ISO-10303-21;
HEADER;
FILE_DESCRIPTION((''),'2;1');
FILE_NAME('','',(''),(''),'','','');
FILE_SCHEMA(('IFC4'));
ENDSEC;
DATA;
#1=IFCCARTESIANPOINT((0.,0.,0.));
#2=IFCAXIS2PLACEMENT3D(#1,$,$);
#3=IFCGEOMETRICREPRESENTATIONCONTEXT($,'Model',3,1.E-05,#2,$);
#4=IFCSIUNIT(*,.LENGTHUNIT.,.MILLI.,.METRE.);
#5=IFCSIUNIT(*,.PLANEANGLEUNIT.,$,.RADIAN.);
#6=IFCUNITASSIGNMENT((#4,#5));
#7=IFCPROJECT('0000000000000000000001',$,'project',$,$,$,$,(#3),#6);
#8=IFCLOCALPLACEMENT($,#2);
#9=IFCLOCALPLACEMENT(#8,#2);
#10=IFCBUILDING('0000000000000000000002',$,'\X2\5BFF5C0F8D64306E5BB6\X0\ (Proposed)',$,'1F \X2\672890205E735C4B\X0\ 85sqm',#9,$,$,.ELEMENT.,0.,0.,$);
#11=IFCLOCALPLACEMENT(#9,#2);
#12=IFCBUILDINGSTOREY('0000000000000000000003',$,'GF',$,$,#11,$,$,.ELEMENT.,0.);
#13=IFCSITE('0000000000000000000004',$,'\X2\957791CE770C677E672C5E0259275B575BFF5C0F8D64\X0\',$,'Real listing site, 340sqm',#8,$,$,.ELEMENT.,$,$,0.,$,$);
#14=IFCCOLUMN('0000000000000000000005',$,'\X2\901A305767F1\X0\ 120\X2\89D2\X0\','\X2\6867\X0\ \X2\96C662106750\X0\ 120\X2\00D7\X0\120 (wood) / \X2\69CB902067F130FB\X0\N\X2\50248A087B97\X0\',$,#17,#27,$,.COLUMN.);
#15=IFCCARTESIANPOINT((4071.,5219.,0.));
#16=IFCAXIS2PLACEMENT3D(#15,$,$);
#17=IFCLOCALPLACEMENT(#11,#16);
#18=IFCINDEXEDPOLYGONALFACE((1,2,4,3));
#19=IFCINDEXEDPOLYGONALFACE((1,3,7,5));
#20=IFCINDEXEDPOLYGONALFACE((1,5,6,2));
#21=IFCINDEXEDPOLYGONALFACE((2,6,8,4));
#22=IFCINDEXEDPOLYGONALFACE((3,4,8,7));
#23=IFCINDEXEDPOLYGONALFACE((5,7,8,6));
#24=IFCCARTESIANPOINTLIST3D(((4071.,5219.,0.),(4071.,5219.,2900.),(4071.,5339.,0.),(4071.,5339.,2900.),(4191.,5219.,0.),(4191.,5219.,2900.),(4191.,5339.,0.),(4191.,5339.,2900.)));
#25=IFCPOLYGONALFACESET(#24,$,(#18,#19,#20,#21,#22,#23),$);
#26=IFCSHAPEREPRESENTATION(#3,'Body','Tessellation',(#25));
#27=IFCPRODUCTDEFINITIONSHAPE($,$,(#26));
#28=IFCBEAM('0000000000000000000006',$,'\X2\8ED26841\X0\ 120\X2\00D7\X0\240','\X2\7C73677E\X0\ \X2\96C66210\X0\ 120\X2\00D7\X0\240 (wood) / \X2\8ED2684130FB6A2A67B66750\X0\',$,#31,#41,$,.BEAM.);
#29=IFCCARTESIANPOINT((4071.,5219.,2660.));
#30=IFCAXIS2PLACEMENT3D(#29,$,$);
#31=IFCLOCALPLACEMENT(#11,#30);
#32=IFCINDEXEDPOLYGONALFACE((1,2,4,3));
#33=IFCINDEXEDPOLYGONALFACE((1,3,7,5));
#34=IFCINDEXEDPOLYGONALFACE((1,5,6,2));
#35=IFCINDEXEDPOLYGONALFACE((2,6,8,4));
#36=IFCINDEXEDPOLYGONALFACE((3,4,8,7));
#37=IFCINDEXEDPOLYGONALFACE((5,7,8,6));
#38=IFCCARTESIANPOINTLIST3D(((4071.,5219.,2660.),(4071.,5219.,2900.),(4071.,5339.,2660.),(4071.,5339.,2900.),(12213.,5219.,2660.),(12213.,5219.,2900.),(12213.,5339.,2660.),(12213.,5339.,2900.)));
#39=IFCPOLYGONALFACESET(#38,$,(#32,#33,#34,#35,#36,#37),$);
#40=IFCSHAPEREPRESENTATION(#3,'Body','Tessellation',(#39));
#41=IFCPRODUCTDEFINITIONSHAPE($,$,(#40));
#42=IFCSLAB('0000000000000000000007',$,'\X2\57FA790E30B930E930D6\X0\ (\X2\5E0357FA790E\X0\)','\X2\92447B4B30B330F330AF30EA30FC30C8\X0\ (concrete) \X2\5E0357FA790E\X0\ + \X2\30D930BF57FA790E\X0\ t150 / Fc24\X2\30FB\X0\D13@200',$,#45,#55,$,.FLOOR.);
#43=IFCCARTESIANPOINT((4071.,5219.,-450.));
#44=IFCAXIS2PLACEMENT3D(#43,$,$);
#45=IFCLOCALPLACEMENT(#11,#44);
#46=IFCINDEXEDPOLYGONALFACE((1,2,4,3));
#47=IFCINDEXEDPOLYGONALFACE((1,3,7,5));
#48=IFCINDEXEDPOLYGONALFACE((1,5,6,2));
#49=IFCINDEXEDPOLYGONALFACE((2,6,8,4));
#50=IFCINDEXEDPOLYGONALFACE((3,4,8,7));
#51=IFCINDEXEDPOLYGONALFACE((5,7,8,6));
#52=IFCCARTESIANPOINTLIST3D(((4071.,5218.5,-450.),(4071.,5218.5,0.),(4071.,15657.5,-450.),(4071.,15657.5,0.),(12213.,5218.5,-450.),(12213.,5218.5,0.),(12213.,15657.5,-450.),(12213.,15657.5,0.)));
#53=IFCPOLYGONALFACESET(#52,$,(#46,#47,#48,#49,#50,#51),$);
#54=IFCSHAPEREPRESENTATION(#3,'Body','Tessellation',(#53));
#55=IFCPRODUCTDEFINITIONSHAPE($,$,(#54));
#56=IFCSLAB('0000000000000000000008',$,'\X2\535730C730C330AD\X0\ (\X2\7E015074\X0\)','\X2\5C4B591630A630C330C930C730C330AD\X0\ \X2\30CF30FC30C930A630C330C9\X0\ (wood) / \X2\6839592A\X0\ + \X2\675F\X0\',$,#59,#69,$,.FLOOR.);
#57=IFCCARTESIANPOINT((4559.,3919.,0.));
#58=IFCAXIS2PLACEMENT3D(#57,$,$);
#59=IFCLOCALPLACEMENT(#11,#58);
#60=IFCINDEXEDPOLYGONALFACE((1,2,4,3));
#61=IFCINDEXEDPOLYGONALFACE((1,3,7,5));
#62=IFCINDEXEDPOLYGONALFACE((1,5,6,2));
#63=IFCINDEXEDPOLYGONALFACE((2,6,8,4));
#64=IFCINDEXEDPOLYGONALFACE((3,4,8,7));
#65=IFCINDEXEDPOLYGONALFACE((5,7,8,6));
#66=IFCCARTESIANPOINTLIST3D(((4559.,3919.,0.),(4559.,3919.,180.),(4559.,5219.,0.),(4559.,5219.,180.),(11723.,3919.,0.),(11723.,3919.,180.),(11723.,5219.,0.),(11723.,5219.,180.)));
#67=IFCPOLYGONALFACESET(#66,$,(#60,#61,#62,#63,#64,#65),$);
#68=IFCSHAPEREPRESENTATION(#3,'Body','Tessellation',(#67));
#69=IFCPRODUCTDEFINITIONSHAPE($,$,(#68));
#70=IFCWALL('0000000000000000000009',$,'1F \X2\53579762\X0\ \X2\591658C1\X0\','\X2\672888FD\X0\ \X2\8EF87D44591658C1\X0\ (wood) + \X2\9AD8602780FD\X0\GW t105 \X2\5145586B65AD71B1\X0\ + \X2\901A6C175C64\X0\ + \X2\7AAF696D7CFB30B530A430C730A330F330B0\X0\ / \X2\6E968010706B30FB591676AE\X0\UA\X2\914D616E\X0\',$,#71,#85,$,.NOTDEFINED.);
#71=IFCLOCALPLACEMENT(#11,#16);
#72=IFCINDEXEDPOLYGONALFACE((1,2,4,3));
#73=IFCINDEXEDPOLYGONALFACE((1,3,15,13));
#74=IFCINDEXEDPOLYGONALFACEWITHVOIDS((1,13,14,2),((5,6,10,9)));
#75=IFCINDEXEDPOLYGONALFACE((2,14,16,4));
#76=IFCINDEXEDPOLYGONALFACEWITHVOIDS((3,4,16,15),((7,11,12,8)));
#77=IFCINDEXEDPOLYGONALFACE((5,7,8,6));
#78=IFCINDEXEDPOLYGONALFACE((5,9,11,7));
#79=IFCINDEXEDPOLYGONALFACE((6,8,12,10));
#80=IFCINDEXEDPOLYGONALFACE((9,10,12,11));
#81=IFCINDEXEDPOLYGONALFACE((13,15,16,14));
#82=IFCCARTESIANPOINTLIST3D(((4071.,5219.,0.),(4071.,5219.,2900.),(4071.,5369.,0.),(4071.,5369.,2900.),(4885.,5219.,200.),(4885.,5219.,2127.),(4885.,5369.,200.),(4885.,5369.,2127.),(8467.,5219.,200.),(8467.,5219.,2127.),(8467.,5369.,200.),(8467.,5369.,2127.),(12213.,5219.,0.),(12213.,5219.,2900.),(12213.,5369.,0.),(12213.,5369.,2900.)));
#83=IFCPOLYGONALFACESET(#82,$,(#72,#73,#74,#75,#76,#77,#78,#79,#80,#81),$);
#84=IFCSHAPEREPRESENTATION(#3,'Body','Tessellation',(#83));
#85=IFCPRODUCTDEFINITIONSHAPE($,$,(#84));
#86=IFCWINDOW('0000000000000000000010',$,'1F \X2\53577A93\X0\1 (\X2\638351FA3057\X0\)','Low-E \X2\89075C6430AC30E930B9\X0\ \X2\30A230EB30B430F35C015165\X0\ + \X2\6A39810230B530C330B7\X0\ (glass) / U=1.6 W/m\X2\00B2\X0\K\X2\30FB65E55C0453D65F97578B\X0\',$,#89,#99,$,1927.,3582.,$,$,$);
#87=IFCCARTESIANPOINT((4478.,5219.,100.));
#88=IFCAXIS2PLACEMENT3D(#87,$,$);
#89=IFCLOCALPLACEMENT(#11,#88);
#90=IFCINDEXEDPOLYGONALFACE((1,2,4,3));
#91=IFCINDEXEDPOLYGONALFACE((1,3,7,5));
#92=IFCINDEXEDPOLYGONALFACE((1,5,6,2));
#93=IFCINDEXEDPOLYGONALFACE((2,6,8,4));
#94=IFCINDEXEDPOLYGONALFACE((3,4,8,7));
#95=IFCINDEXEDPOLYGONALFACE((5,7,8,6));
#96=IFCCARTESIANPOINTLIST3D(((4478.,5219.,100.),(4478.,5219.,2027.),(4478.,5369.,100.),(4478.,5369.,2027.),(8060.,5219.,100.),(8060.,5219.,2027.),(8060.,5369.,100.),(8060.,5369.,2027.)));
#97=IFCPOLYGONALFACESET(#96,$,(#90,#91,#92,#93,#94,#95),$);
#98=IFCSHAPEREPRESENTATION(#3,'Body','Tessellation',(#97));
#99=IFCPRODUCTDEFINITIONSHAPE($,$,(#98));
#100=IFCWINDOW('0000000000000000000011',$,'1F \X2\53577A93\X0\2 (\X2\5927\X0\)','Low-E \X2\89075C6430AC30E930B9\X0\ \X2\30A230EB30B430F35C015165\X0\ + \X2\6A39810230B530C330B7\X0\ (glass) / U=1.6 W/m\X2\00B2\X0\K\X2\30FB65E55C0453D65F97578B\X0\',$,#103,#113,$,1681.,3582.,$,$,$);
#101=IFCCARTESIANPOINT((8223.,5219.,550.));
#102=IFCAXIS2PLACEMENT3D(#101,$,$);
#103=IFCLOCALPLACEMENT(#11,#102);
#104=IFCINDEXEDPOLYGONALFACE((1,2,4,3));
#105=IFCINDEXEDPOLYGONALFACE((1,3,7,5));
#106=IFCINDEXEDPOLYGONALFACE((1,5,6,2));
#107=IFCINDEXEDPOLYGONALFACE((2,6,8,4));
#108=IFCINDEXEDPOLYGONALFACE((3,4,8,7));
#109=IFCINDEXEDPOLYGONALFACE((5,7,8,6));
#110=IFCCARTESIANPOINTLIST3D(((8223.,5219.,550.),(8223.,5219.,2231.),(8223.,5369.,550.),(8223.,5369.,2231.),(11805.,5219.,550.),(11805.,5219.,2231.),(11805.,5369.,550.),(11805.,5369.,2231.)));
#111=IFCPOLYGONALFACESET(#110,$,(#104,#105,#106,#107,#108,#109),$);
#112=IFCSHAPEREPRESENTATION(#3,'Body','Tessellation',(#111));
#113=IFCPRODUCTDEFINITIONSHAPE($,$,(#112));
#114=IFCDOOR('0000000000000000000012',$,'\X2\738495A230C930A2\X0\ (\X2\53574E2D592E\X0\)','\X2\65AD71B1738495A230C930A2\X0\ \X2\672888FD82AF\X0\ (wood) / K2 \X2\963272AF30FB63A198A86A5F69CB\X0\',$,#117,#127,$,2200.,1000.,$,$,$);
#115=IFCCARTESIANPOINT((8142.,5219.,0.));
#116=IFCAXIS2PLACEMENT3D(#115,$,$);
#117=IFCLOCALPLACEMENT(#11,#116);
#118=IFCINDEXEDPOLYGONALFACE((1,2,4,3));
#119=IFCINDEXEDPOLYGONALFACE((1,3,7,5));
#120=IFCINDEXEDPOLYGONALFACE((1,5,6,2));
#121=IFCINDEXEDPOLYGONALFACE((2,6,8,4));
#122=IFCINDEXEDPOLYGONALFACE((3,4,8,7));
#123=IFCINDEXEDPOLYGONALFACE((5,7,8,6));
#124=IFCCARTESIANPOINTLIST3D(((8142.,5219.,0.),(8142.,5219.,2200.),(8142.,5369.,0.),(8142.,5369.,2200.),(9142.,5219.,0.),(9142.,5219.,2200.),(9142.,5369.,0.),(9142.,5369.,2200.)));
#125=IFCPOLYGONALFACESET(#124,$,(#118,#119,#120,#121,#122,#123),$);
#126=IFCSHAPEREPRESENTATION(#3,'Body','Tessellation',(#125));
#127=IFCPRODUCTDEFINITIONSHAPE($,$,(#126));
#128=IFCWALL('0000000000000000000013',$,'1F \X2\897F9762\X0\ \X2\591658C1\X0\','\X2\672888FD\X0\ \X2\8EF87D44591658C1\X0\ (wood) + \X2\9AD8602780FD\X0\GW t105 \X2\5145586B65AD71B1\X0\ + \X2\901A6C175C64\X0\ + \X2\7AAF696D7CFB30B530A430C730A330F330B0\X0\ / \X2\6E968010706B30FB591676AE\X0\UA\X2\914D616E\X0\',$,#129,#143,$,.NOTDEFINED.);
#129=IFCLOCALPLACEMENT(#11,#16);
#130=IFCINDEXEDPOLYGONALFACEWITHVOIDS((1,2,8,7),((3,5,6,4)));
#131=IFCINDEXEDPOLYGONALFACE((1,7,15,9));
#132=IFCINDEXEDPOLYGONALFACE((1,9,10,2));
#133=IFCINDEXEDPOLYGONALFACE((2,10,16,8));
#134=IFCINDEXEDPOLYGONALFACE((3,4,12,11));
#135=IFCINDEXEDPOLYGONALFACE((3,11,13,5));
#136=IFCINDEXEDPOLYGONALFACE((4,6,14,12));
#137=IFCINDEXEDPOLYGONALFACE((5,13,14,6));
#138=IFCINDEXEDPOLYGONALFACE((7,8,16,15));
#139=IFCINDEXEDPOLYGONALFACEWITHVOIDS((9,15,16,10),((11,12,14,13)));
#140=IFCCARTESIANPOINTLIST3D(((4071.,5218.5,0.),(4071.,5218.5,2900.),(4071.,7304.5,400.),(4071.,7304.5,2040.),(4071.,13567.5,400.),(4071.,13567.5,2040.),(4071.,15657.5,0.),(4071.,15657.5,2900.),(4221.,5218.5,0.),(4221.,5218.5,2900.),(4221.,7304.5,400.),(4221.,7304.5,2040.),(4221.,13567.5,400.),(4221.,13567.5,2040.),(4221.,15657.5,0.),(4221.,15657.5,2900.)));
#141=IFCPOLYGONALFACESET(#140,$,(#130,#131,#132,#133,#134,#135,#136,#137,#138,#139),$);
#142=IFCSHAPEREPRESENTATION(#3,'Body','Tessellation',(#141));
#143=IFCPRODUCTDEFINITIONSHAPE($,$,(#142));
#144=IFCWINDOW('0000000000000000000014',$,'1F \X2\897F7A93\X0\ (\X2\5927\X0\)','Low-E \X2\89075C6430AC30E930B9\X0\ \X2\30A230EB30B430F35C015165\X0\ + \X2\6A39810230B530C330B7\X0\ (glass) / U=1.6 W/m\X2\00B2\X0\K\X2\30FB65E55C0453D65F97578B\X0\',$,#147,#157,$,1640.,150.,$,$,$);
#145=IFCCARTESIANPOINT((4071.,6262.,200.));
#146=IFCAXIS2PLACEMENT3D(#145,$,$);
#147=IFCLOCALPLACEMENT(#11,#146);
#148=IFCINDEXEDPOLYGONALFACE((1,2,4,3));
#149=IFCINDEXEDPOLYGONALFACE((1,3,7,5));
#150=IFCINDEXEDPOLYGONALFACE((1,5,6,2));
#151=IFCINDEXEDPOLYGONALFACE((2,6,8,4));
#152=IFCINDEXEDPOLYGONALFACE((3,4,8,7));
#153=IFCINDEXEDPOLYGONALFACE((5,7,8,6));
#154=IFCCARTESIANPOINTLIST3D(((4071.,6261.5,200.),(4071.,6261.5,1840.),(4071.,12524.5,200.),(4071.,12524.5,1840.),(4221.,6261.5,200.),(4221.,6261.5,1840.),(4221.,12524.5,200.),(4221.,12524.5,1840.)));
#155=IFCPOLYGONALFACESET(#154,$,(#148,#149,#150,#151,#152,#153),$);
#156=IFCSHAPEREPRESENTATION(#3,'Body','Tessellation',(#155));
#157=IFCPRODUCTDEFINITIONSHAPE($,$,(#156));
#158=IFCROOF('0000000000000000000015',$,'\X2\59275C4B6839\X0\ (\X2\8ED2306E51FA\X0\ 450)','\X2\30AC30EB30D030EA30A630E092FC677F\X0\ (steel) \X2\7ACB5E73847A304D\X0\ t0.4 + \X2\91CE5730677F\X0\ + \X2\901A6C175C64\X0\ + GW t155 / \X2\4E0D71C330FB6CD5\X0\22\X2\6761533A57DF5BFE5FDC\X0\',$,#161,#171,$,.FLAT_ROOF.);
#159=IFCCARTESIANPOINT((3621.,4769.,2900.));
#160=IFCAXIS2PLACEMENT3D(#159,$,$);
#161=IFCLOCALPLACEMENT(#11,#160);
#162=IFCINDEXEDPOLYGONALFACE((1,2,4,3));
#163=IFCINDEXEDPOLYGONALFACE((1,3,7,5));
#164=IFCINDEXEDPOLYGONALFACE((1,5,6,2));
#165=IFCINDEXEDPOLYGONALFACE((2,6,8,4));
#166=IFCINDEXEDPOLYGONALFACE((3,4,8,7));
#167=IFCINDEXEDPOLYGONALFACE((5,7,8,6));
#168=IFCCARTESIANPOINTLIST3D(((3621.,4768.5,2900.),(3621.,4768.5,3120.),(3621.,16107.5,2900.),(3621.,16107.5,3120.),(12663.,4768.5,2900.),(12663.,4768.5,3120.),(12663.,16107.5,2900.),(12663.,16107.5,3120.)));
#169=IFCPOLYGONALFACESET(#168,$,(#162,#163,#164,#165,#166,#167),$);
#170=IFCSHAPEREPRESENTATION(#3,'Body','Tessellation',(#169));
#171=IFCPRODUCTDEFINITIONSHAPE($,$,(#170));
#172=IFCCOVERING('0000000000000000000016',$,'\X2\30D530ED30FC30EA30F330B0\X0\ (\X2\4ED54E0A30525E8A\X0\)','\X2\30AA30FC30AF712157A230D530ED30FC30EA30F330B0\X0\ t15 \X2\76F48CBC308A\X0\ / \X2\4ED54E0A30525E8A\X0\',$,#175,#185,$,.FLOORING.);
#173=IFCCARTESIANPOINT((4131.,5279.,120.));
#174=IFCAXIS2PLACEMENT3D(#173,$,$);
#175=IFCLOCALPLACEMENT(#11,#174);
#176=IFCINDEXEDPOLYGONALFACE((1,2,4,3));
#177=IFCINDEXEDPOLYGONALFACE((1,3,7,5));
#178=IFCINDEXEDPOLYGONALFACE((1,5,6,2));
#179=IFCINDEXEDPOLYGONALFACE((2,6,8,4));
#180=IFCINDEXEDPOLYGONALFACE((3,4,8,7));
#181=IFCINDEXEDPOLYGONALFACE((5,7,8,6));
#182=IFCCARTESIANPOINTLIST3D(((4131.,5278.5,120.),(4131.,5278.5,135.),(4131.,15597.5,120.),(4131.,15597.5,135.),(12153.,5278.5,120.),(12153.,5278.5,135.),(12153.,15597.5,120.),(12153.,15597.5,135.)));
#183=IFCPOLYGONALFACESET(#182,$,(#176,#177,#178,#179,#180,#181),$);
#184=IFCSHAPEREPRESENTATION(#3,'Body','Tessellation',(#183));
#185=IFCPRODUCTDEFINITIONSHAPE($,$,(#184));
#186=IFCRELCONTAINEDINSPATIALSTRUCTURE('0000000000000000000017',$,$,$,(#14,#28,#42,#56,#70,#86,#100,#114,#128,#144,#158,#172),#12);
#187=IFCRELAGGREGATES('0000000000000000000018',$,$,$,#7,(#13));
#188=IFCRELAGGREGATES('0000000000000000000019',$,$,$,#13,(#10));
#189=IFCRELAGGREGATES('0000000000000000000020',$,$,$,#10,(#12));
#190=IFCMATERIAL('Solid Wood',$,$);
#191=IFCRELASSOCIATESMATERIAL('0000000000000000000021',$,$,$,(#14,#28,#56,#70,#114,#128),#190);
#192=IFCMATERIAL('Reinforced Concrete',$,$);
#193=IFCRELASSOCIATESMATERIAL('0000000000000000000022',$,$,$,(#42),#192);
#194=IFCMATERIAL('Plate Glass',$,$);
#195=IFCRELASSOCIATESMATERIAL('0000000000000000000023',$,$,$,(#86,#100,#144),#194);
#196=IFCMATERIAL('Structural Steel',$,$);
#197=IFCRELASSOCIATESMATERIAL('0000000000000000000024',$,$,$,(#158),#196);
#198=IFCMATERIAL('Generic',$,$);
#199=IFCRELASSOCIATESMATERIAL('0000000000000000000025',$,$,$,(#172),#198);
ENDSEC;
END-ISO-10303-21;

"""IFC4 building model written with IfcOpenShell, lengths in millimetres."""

from ifc_helpers import new_model, si_unit, frame, frame_2d, origin, place, context, project, spatial, rectangle, extrude, material, element, fill, save


model = new_model("IFC4")

# Units and contexts
model_context = context("Model", 3, precision=1e-05, world=origin())
ifc_project = project(units=[si_unit("LENGTHUNIT", "METRE", prefix="MILLI"), si_unit("PLANEANGLEUNIT", "RADIAN")], contexts=[model_context])

# Site, building, storey
site_placement = place(None, origin())
site = spatial("IfcSite", under=ifc_project, at=site_placement, Name="長野県松本市大字寿小赤", ObjectType="Real listing site, 340sqm", CompositionType="ELEMENT", RefElevation=0.0)
building_placement = place(site_placement, origin())
building = spatial("IfcBuilding", under=site, at=building_placement, Name="寿小赤の家 (Proposed)", ObjectType="1F 木造平屋 85sqm", CompositionType="ELEMENT", ElevationOfRefHeight=0.0, ElevationOfTerrain=0.0)
storey_placement = place(building_placement, origin())
storey = spatial("IfcBuildingStorey", under=building, at=storey_placement, Name="GF", CompositionType="ELEMENT", Elevation=0.0)

# Column
ifc_material_1 = material(Name="Solid Wood")
column_1_placement = place(storey_placement, frame((4071.0, 5219.0, 0.0)))
element("IfcColumn", 1, at=column_1_placement, inside=storey, material=ifc_material_1, Name="通し柱 120角", Description="桧 集成材 120×120 (wood) / 構造柱・N値計算", PredefinedType="COLUMN", context=model_context, shape_type="SweptSolid", body=[
    extrude(rectangle(XDim=120.0, YDim=120.0, at=frame_2d((60.0, 60.0))), frame((4071.0, 5219.0, 0.0)), (0.0, 0.0, 1.0), 2900.0),
])

# Beam
beam_1_placement = place(storey_placement, frame((4071.0, 5219.0, 2660.0)))
element("IfcBeam", 2, at=beam_1_placement, inside=storey, material=ifc_material_1, Name="軒桁 120×240", Description="米松 集成 120×240 (wood) / 軒桁・横架材", PredefinedType="BEAM", context=model_context, shape_type="SweptSolid", body=[
    extrude(rectangle(XDim=8142.0, YDim=120.0, at=frame_2d((4071.0, 60.0))), frame((4071.0, 5219.0, 2660.0)), (0.0, 0.0, 1.0), 240.0),
])

# Slabs
ifc_material_2 = material(Name="Reinforced Concrete")
slab_1_placement = place(storey_placement, frame((4071.0, 5219.0, -450.0)))
element("IfcSlab", 3, at=slab_1_placement, inside=storey, material=ifc_material_2, Name="基礎スラブ (布基礎)", Description="鉄筋コンクリート (concrete) 布基礎 + ベタ基礎 t150 / Fc24・D13@200", PredefinedType="FLOOR", context=model_context, shape_type="SweptSolid", body=[
    extrude(rectangle(XDim=8142.0, YDim=10439.0, at=frame_2d((4071.0, 5219.0))), frame((4071.0, 5219.0, -450.0)), (0.0, 0.0, 1.0), 450.0),
])
slab_2_placement = place(storey_placement, frame((4559.0, 3919.0, 0.0)))
element("IfcSlab", 4, at=slab_2_placement, inside=storey, material=ifc_material_1, Name="南デッキ (縁側)", Description="屋外ウッドデッキ ハードウッド (wood) / 根太 + 束", PredefinedType="FLOOR", context=model_context, shape_type="SweptSolid", body=[
    extrude(rectangle(XDim=7164.0, YDim=1300.0, at=frame_2d((3582.0, 650.0))), frame((4559.0, 3919.0, 0.0)), (0.0, 0.0, 1.0), 180.0),
])

# Wall, openings, windows, door
wall_1_placement = place(storey_placement, frame((4071.0, 5219.0, 0.0)))
wall_1 = element("IfcWall", 5, at=wall_1_placement, inside=storey, material=ifc_material_1, Name="1F 南面 外壁", Description="木製 軸組外壁 (wood) + 高性能GW t105 充填断熱 + 通気層 + 窯業系サイディング / 準耐火・外皮UA配慮", PredefinedType="NOTDEFINED", context=model_context, shape_type="SweptSolid", body=[
    extrude(rectangle(XDim=8142.0, YDim=150.0, at=frame_2d((4071.0, 75.0))), frame((4071.0, 5219.0, 0.0)), (0.0, 0.0, 1.0), 2900.0),
])
opening_1_placement = place(storey_placement, frame((4478.0, 5219.0, 100.0)))
opening_1 = element("IfcOpeningElement", 6, at=opening_1_placement, cuts=wall_1, PredefinedType="NOTDEFINED", context=model_context, shape_type="SweptSolid", body=[
    extrude(rectangle(XDim=3582.0, YDim=150.0, at=frame_2d((1791.0, 75.0))), frame((4478.0, 5219.0, 100.0)), (0.0, 0.0, 1.0), 1927.0),
])
opening_2_placement = place(storey_placement, frame((8223.0, 5219.0, 550.0)))
opening_2 = element("IfcOpeningElement", 7, at=opening_2_placement, cuts=wall_1, PredefinedType="NOTDEFINED", context=model_context, shape_type="SweptSolid", body=[
    extrude(rectangle(XDim=3582.0, YDim=150.0, at=frame_2d((1791.0, 75.0))), frame((8223.0, 5219.0, 550.0)), (0.0, 0.0, 1.0), 1681.0),
])
opening_3_placement = place(storey_placement, frame((8142.0, 5219.0, 0.0)))
opening_3 = element("IfcOpeningElement", 8, at=opening_3_placement, cuts=wall_1, PredefinedType="NOTDEFINED", context=model_context, shape_type="SweptSolid", body=[
    extrude(rectangle(XDim=1000.0, YDim=150.0, at=frame_2d((500.0, 75.0))), frame((8142.0, 5219.0, 0.0)), (0.0, 0.0, 1.0), 2200.0),
])
ifc_material_3 = material(Name="Plate Glass")
window_1_placement = place(storey_placement, frame((4478.0, 5219.0, 100.0)))
window_1 = element("IfcWindow", 9, at=window_1_placement, inside=storey, material=ifc_material_3, Name="1F 南窓1 (掃出し)", Description="Low-E 複層ガラス アルゴン封入 + 樹脂サッシ (glass) / U=1.6 W/m²K・日射取得型", OverallHeight=1927.0, OverallWidth=3582.0, context=model_context, shape_type="SweptSolid", body=[
    extrude(rectangle(XDim=3582.0, YDim=150.0, at=frame_2d((1791.0, 75.0))), frame((4478.0, 5219.0, 100.0)), (0.0, 0.0, 1.0), 1927.0),
])
fill(opening_1, window_1)
window_2_placement = place(storey_placement, frame((8223.0, 5219.0, 550.0)))
window_2 = element("IfcWindow", 10, at=window_2_placement, inside=storey, material=ifc_material_3, Name="1F 南窓2 (大)", Description="Low-E 複層ガラス アルゴン封入 + 樹脂サッシ (glass) / U=1.6 W/m²K・日射取得型", OverallHeight=1681.0, OverallWidth=3582.0, context=model_context, shape_type="SweptSolid", body=[
    extrude(rectangle(XDim=3582.0, YDim=150.0, at=frame_2d((1791.0, 75.0))), frame((8223.0, 5219.0, 550.0)), (0.0, 0.0, 1.0), 1681.0),
])
fill(opening_2, window_2)
door_placement = place(storey_placement, frame((8142.0, 5219.0, 0.0)))
door = element("IfcDoor", 11, at=door_placement, inside=storey, material=ifc_material_1, Name="玄関ドア (南中央)", Description="断熱玄関ドア 木製芯 (wood) / K2 防犯・採風機構", OverallHeight=2200.0, OverallWidth=1000.0, context=model_context, shape_type="SweptSolid", body=[
    extrude(rectangle(XDim=1000.0, YDim=150.0, at=frame_2d((500.0, 75.0))), frame((8142.0, 5219.0, 0.0)), (0.0, 0.0, 1.0), 2200.0),
])
fill(opening_3, door)

# Wall, opening, window
wall_2_placement = place(storey_placement, frame((4071.0, 5219.0, 0.0)))
wall_2 = element("IfcWall", 12, at=wall_2_placement, inside=storey, material=ifc_material_1, Name="1F 西面 外壁", Description="木製 軸組外壁 (wood) + 高性能GW t105 充填断熱 + 通気層 + 窯業系サイディング / 準耐火・外皮UA配慮", PredefinedType="NOTDEFINED", context=model_context, shape_type="SweptSolid", body=[
    extrude(rectangle(XDim=150.0, YDim=10439.0, at=frame_2d((75.0, 5219.0))), frame((4071.0, 5219.0, 0.0)), (0.0, 0.0, 1.0), 2900.0),
])
opening_4_placement = place(storey_placement, frame((4071.0, 6262.0, 200.0)))
opening_4 = element("IfcOpeningElement", 13, at=opening_4_placement, cuts=wall_2, PredefinedType="NOTDEFINED", context=model_context, shape_type="SweptSolid", body=[
    extrude(rectangle(XDim=150.0, YDim=6263.0, at=frame_2d((75.0, 3131.0))), frame((4071.0, 6262.0, 200.0)), (0.0, 0.0, 1.0), 1640.0),
])
window_3_placement = place(storey_placement, frame((4071.0, 6262.0, 200.0)))
window_3 = element("IfcWindow", 14, at=window_3_placement, inside=storey, material=ifc_material_3, Name="1F 西窓 (大)", Description="Low-E 複層ガラス アルゴン封入 + 樹脂サッシ (glass) / U=1.6 W/m²K・日射取得型", OverallHeight=1640.0, OverallWidth=150.0, context=model_context, shape_type="SweptSolid", body=[
    extrude(rectangle(XDim=150.0, YDim=6263.0, at=frame_2d((75.0, 3131.0))), frame((4071.0, 6262.0, 200.0)), (0.0, 0.0, 1.0), 1640.0),
])
fill(opening_4, window_3)

# Roof
ifc_material_4 = material(Name="Structural Steel")
roof_placement = place(storey_placement, frame((3621.0, 4769.0, 2900.0)))
element("IfcRoof", 15, at=roof_placement, inside=storey, material=ifc_material_4, Name="大屋根 (軒の出 450)", Description="ガルバリウム鋼板 (steel) 立平葺き t0.4 + 野地板 + 通気層 + GW t155 / 不燃・法22条区域対応", PredefinedType="FLAT_ROOF", context=model_context, shape_type="SweptSolid", body=[
    extrude(rectangle(XDim=9042.0, YDim=11339.0, at=frame_2d((4521.0, 5669.0))), frame((3621.0, 4769.0, 2900.0)), (0.0, 0.0, 1.0), 220.0),
])

# Covering
ifc_material_5 = material(Name="Generic")
covering_1_placement = place(storey_placement, frame((4131.0, 5279.0, 120.0)))
element("IfcCovering", 16, at=covering_1_placement, inside=storey, material=ifc_material_5, Name="フローリング (仕上げ床)", Description="オーク無垢フローリング t15 直貼り / 仕上げ床", PredefinedType="FLOORING", context=model_context, shape_type="SweptSolid", body=[
    extrude(rectangle(XDim=8022.0, YDim=10319.0, at=frame_2d((4011.0, 5159.0))), frame((4131.0, 5279.0, 120.0)), (0.0, 0.0, 1.0), 15.0),
])

save(model, "model.ifc")
